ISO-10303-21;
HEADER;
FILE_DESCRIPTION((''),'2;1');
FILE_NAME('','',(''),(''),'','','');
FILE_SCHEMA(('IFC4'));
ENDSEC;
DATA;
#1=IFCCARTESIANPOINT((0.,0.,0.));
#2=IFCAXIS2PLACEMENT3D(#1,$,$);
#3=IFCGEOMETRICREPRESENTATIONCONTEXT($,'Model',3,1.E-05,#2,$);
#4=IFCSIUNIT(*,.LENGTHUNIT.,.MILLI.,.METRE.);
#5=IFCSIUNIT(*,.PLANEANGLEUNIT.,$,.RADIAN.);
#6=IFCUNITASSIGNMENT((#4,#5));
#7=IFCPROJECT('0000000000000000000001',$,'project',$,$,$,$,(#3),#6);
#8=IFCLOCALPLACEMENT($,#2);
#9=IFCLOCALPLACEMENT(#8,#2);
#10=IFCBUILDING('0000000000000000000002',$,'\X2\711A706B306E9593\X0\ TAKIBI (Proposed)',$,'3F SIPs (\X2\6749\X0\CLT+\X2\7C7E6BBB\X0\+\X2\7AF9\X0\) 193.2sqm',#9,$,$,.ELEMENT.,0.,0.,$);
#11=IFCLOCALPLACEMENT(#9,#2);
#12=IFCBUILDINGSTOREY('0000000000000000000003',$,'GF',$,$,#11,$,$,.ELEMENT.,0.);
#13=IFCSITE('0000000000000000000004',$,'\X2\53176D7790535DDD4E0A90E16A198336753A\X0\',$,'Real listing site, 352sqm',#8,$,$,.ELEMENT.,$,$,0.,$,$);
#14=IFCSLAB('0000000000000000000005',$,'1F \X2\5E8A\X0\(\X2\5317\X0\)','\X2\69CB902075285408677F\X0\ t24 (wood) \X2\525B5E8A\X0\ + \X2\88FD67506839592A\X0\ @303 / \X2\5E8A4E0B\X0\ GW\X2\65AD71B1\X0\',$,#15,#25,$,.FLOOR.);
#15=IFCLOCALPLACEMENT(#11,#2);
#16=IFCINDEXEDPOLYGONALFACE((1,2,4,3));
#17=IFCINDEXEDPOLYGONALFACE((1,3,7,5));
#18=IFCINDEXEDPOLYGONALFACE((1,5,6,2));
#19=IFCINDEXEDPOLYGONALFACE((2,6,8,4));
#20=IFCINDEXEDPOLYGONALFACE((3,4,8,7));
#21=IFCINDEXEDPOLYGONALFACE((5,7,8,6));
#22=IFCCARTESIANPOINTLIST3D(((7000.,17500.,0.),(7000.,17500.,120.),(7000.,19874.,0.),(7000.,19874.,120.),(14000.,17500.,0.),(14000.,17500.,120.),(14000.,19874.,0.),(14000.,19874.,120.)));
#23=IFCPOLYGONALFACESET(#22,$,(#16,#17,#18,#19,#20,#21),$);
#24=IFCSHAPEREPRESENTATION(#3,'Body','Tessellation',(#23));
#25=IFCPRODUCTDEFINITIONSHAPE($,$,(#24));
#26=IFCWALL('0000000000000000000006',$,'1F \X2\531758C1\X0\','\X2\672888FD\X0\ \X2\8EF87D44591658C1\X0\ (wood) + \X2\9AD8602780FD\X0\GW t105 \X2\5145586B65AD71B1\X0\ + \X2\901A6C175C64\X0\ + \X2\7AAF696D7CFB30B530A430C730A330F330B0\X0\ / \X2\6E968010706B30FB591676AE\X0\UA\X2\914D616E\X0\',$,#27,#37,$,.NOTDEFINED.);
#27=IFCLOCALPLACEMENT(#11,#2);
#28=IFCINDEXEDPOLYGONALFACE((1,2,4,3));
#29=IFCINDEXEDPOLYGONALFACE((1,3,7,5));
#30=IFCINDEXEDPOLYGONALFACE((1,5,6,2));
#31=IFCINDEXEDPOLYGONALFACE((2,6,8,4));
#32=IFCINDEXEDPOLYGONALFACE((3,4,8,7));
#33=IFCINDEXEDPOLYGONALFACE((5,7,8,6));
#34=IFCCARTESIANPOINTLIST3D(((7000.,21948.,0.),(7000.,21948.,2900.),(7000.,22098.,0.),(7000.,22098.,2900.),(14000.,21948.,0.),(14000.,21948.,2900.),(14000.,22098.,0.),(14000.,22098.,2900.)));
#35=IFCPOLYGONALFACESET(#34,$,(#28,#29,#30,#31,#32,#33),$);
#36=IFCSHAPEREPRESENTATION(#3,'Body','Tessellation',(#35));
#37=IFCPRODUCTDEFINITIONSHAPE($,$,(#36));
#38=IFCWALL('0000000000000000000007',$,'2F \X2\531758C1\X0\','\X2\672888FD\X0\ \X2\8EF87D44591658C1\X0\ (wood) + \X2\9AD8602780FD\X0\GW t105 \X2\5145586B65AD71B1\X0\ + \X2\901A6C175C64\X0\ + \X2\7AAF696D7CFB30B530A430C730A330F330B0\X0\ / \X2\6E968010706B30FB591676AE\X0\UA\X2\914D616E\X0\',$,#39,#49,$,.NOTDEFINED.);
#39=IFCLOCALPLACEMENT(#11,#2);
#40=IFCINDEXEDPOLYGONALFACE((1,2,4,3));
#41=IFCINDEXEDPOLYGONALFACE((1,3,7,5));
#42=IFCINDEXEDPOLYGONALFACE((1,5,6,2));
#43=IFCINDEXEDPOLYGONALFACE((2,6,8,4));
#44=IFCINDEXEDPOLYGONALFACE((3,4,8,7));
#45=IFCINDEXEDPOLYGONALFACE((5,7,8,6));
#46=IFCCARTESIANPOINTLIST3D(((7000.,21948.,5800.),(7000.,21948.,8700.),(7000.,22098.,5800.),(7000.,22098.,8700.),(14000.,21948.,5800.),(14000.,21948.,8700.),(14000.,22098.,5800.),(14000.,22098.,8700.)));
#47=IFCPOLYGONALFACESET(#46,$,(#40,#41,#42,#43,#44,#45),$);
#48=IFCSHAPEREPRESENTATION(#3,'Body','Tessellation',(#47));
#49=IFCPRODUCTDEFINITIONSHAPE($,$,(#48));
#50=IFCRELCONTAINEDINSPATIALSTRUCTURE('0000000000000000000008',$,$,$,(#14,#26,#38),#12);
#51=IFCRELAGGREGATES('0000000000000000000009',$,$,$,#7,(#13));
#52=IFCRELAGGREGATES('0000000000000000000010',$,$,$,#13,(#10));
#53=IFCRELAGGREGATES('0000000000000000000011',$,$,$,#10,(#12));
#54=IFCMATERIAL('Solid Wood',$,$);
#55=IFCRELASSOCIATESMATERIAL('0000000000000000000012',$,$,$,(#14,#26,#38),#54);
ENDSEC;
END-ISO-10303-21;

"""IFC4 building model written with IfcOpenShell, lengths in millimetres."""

from ifc_helpers import new_model, si_unit, frame, frame_2d, origin, place, context, project, spatial, rectangle, extrude, material, element, save


model = new_model("IFC4")

# Units and contexts
model_context = context("Model", 3, precision=1e-05, world=origin())
ifc_project = project(units=[si_unit("LENGTHUNIT", "METRE", prefix="MILLI"), si_unit("PLANEANGLEUNIT", "RADIAN")], contexts=[model_context])

# Site, building, storey
site_placement = place(None, origin())
site = spatial("IfcSite", under=ifc_project, at=site_placement, Name="北海道川上郡標茶町", ObjectType="Real listing site, 352sqm", CompositionType="ELEMENT", RefElevation=0.0)
building_placement = place(site_placement, origin())
building = spatial("IfcBuilding", under=site, at=building_placement, Name="焚火の間 TAKIBI (Proposed)", ObjectType="3F SIPs (杉CLT+籾殻+竹) 193.2sqm", CompositionType="ELEMENT", ElevationOfRefHeight=0.0, ElevationOfTerrain=0.0)
storey_placement = place(building_placement, origin())
storey = spatial("IfcBuildingStorey", under=building, at=storey_placement, Name="GF", CompositionType="ELEMENT", Elevation=0.0)

# Slab
ifc_material_1 = material(Name="Solid Wood")
slab_1_placement = place(storey_placement, frame((3500.0, 8750.0, 0.0)))
element("IfcSlab", 1, at=slab_1_placement, inside=storey, material=ifc_material_1, Name="1F 床(北)", Description="構造用合板 t24 (wood) 剛床 + 製材根太 @303 / 床下 GW断熱", PredefinedType="FLOOR", context=model_context, shape_type="SweptSolid", body=[
    extrude(rectangle(XDim=7000.0, YDim=2374.0, at=frame_2d((3500.0, 1187.0))), frame((3500.0, 8750.0, 0.0)), (0.0, 0.0, 1.0), 120.0),
])

# Wall
wall_1_placement = place(storey_placement, frame((3500.0, 10974.0, 0.0)))
element("IfcWall", 2, at=wall_1_placement, inside=storey, material=ifc_material_1, Name="1F 北壁", Description="木製 軸組外壁 (wood) + 高性能GW t105 充填断熱 + 通気層 + 窯業系サイディング / 準耐火・外皮UA配慮", PredefinedType="NOTDEFINED", context=model_context, shape_type="SweptSolid", body=[
    extrude(rectangle(XDim=7000.0, YDim=150.0, at=frame_2d((3500.0, 75.0))), frame((3500.0, 10974.0, 0.0)), (0.0, 0.0, 1.0), 2900.0),
])

# Wall
wall_2_placement = place(storey_placement, frame((3500.0, 10974.0, 2900.0)))
element("IfcWall", 3, at=wall_2_placement, inside=storey, material=ifc_material_1, Name="2F 北壁", Description="木製 軸組外壁 (wood) + 高性能GW t105 充填断熱 + 通気層 + 窯業系サイディング / 準耐火・外皮UA配慮", PredefinedType="NOTDEFINED", context=model_context, shape_type="SweptSolid", body=[
    extrude(rectangle(XDim=7000.0, YDim=150.0, at=frame_2d((3500.0, 75.0))), frame((3500.0, 10974.0, 2900.0)), (0.0, 0.0, 1.0), 2900.0),
])

save(model, "model.ifc")
